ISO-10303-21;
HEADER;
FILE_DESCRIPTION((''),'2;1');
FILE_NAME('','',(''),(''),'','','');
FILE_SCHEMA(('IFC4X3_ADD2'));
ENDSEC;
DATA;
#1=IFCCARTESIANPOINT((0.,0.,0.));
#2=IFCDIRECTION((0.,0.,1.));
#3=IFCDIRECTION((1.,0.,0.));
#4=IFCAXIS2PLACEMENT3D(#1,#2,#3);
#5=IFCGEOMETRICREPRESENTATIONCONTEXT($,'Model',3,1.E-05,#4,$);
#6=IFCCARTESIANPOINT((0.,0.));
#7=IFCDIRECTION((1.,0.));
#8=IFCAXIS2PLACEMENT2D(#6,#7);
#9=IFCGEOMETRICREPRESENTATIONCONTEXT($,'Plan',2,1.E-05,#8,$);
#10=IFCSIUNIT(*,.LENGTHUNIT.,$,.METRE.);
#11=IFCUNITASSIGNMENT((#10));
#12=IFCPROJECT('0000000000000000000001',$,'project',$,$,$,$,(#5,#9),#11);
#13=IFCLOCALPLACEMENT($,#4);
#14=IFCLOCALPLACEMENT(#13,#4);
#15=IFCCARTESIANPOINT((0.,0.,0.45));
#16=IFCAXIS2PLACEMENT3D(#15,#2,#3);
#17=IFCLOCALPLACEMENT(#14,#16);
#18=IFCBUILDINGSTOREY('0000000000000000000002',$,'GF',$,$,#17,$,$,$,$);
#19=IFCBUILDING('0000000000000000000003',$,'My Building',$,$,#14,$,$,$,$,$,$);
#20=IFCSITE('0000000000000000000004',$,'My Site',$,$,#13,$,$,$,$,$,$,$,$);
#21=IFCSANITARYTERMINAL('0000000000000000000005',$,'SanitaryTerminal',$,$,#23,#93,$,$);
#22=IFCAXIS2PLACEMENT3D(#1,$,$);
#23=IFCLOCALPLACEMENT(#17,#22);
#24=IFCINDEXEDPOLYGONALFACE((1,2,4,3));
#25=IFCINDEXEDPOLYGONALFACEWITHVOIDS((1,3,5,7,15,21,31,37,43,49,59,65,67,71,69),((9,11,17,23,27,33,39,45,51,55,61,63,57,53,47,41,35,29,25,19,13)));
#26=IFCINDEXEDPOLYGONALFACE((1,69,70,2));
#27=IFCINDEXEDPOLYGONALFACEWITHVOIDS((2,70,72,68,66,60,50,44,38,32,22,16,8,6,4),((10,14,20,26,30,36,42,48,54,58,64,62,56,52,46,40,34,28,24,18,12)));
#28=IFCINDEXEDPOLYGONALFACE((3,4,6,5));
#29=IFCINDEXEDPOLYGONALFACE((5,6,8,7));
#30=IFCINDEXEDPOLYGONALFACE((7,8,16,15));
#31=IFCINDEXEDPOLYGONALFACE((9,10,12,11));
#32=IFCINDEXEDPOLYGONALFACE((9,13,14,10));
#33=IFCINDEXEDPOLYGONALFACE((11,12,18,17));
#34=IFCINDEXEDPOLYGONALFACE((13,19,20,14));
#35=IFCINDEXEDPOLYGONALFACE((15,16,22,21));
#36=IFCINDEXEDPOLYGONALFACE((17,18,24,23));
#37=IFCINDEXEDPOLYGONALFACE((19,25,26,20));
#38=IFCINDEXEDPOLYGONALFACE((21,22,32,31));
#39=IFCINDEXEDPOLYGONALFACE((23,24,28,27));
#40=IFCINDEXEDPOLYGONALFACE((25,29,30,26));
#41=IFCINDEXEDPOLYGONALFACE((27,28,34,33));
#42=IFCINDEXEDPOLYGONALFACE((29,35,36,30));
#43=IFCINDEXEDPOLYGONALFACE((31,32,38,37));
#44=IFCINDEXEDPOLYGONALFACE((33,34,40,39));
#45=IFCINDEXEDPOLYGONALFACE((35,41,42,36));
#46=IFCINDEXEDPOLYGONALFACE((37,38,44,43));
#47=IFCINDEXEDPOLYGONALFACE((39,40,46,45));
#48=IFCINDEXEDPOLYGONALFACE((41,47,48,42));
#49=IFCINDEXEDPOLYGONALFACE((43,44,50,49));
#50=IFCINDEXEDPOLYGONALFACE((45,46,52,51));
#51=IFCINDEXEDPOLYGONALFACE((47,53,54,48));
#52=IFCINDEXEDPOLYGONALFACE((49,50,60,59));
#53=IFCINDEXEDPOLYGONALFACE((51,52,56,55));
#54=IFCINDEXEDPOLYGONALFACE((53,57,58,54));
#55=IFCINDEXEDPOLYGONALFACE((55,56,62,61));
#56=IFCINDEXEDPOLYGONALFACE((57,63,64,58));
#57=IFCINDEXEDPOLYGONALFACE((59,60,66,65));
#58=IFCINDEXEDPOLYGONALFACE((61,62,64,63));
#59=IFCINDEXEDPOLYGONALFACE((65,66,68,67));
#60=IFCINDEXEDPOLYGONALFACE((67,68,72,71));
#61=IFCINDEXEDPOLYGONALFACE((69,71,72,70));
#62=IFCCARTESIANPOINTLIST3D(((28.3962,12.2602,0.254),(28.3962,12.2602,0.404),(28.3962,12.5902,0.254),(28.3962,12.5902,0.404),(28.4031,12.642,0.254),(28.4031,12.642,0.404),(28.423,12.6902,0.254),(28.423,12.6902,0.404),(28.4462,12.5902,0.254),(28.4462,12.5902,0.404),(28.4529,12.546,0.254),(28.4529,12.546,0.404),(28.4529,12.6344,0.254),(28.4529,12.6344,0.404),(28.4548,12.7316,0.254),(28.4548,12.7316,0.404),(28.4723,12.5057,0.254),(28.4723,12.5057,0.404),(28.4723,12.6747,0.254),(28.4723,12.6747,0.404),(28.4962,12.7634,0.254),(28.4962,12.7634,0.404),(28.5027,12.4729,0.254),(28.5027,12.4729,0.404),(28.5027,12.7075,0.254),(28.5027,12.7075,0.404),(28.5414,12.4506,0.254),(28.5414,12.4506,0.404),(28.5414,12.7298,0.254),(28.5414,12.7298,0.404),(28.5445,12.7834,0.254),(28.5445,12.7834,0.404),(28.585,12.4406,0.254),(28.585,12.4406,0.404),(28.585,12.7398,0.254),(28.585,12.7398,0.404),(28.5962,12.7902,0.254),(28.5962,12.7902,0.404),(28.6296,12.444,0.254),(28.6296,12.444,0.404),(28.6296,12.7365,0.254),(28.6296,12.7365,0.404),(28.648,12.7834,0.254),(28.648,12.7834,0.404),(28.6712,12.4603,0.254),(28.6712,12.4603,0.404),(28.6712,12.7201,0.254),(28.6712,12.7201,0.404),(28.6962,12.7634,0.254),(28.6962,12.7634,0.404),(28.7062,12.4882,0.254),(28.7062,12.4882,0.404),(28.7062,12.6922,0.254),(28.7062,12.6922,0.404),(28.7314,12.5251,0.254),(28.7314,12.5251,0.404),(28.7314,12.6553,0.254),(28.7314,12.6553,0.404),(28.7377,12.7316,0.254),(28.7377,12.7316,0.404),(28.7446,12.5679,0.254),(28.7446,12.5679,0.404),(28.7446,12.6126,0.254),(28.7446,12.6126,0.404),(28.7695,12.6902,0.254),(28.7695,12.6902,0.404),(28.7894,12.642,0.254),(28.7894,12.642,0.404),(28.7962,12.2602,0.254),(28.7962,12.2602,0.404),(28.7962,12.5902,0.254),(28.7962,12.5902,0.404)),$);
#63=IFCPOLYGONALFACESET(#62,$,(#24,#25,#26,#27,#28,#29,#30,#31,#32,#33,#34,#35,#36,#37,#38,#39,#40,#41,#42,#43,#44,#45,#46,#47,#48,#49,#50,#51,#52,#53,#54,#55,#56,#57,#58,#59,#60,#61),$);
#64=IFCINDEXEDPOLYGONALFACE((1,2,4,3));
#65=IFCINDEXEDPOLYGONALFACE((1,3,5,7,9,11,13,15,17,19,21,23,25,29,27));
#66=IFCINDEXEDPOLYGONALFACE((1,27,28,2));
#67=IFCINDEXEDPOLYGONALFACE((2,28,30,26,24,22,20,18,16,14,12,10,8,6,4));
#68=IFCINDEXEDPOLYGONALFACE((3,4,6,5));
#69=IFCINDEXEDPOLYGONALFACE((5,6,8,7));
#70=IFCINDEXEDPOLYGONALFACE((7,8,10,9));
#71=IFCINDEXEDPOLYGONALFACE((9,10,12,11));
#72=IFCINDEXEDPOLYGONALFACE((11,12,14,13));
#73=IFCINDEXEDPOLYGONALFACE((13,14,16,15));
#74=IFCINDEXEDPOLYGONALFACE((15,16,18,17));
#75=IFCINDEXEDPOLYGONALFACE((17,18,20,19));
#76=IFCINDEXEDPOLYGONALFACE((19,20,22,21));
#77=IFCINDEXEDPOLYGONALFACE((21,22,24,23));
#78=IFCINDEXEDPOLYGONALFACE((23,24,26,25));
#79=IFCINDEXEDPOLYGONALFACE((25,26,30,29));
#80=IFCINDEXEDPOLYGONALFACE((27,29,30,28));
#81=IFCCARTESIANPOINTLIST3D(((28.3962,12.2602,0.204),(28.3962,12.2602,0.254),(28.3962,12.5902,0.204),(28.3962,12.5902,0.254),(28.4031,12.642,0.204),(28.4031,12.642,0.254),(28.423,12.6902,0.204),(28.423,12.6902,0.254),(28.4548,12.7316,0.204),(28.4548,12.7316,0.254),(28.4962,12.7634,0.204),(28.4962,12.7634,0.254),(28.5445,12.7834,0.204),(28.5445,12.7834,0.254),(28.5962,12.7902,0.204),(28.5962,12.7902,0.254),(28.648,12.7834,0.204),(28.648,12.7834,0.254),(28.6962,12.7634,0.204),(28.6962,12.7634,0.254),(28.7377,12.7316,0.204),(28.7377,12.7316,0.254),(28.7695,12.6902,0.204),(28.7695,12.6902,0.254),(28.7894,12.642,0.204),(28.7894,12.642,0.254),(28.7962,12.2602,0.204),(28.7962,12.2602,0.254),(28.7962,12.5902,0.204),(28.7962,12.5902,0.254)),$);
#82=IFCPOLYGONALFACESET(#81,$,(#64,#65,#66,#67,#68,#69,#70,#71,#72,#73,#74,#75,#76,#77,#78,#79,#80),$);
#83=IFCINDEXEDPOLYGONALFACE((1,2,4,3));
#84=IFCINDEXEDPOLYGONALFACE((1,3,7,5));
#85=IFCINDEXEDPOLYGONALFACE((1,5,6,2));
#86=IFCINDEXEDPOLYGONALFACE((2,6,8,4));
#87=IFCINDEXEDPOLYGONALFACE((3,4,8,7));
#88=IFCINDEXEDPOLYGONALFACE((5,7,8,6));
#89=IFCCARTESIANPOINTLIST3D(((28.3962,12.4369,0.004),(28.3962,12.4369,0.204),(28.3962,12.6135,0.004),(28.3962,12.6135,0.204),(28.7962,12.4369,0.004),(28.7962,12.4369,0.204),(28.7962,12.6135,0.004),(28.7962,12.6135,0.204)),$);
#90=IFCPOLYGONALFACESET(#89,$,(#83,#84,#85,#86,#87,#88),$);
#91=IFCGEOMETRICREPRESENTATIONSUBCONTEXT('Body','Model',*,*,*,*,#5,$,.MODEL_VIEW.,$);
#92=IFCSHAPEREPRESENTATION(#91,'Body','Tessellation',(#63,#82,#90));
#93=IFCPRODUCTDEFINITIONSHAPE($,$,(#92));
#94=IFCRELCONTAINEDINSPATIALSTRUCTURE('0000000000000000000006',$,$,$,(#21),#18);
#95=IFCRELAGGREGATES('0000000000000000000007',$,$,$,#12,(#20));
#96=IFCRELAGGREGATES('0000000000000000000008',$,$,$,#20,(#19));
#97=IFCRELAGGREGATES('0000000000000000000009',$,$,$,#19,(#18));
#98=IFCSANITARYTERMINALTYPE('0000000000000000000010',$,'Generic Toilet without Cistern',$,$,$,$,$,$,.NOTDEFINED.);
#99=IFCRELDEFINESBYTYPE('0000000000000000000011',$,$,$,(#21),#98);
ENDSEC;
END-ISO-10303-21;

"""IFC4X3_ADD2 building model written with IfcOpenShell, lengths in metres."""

from ifc_helpers import new_model, entity, si_unit, frame, frame_2d, origin_with_axes, origin_2d_with_axis, place, context, subcontext, project, spatial, line, arc, indexed_curve, circle_curve, outline, extrude, shape, source, transform, mapped, type_object, type_shapes, element, save


model = new_model("IFC4X3_ADD2")

# Units and contexts
model_context = context("Model", 3, precision=1e-05, world=origin_with_axes())
plan_context = context("Plan", 2, precision=1e-05, world=origin_2d_with_axis())
body_context_1 = subcontext(model_context, "Body", "Model", "MODEL_VIEW")
body_context_2 = subcontext(plan_context, "Body", "Plan", "PLAN_VIEW")
ifc_project = project(units=[si_unit("LENGTHUNIT", "METRE")], contexts=[model_context, plan_context])

# Site, building, storey
site_placement = place(None, origin_with_axes())
site = spatial("IfcSite", under=ifc_project, at=site_placement, Name="My Site")
building_placement = place(site_placement, origin_with_axes())
building = spatial("IfcBuilding", under=site, at=building_placement, Name="My Building")
storey_placement = place(building_placement, frame((0.0, 0.0, 0.45), z_axis=(0.0, 0.0, 1.0), x_axis=(1.0, 0.0, 0.0)))
storey = spatial("IfcBuildingStorey", under=building, at=storey_placement, Name="GF")

# Sanitary terminal
sanitary_terminal_type_1 = type_object("IfcSanitaryTerminalType", Name="Generic Toilet without Cistern", PredefinedType="NOTDEFINED")
shared_shape_1 = source(origin_with_axes(), body_context_1, "Body", "SweptSolid", [
    extrude(outline(indexed_curve([(-0.2, 0.0), (0.2, 0.0), (0.2, -0.33), (0.1414, -0.4714), (0.0, -0.53), (-0.1414, -0.4714), (-0.2, -0.33)], segments=[line(1, 2), line(2, 3), arc(3, 4, 5), arc(5, 6, 7), line(7, 1)]), holes=[circle_curve(frame_2d((0.0, -0.33)), 0.15)]), frame((0.0, 0.0, 0.25), z_axis=(0.0, 0.0, 1.0), x_axis=(1.0, 0.0, 0.0)), (0.0, 0.0, 1.0), 0.15),
    extrude(outline(indexed_curve([(-0.2, 0.0), (0.2, 0.0), (0.2, -0.33), (0.1414, -0.4714), (0.0, -0.53), (-0.1414, -0.4714), (-0.2, -0.33)], segments=[line(1, 2), line(2, 3), arc(3, 4, 5), arc(5, 6, 7), line(7, 1)])), frame((0.0, 0.0, 0.2), z_axis=(0.0, 0.0, 1.0), x_axis=(1.0, 0.0, 0.0)), (0.0, 0.0, 1.0), 0.05),
    extrude(outline(indexed_curve([(-0.2, -0.1767), (0.2, -0.1767), (0.2, -0.3533), (-0.2, -0.3533)], segments=[line(1, 2, 3, 4, 1)])), origin_with_axes(), (0.0, 0.0, 1.0), 0.2),
])
shared_shape_2 = source(origin_with_axes(), body_context_2, "Body", "GeometricSet", [
    entity("IfcGeometricCurveSet", [entity("IfcIndexedPolyCurve", entity("IfcCartesianPointList2D", [[-0.1068, -0.124], [-0.0957, -0.1129], [-0.0804, -0.1088], [0.0804, -0.1088], [0.0957, -0.1129], [0.1068, -0.124], [0.1109, -0.1393], [0.1109, -0.3476], [0.1025, -0.3926], [0.0784, -0.4308], [0.0424, -0.4563], [0.0, -0.4652], [-0.0424, -0.4563], [-0.0784, -0.4308], [-0.1025, -0.3926], [-0.1109, -0.3476], [-0.1109, -0.1393]]), [entity("IfcLineIndex", [1, 2, 3, 4, 5, 6, 7, 8, 9, 10, 11, 12, 13, 14, 15, 16, 17, 1])]), entity("IfcIndexedPolyCurve", entity("IfcCartesianPointList2D", [[-0.1962, -0.2314], [-0.1848, -0.301], [-0.1764, -0.3339], [-0.1663, -0.3651], [-0.1546, -0.3944], [-0.1414, -0.4213], [-0.1269, -0.4458], [-0.1111, -0.4675], [-0.0943, -0.4862], [-0.0765, -0.5018], [-0.0581, -0.514], [-0.039, -0.5229], [-0.0196, -0.5282], [0.0, -0.53], [0.0196, -0.5282], [0.039, -0.5229], [0.0581, -0.514], [0.0765, -0.5018], [0.0943, -0.4862], [0.1111, -0.4675], [0.1269, -0.4458], [0.1414, -0.4213], [0.1546, -0.3944], [0.1663, -0.3651], [0.1764, -0.3339], [0.1848, -0.301], [0.1962, -0.2314], [0.2, -0.159], [0.1872, 0.0], [-0.1872, 0.0], [-0.2, -0.159]]), [entity("IfcLineIndex", [1, 2, 3, 4, 5, 6, 7, 8, 9, 10, 11, 12, 13, 14, 15, 16, 17, 18, 19, 20, 21, 22, 23, 24, 25, 26, 27, 28, 29, 30, 31, 1])])]),
])
type_shapes(sanitary_terminal_type_1, [shared_shape_1, shared_shape_2])
for number, where, z_axis, x_axis, name in (
    (1, (28.5962, 12.2602, 0.004), (0.0, 0.0, 1.0), (-1.0, 0.0, 0.0), "SanitaryTerminal"),
):
    element("IfcSanitaryTerminal", number, at=place(storey_placement, frame(where, z_axis=z_axis, x_axis=x_axis)), inside=storey, type_object=sanitary_terminal_type_1, Name=name, shapes=[
        shape(body_context_1, "Body", "MappedRepresentation", [mapped(shared_shape_1, transform((0.0, 0.0, 0.0), x_axis=(1.0, 0.0, 0.0), y_axis=(0.0, 1.0, 0.0), z_axis=(0.0, 0.0, 1.0), scale=1.0))]),
        shape(body_context_2, "Body", "MappedRepresentation", [mapped(shared_shape_2, transform((0.0, 0.0, 0.0), x_axis=(1.0, 0.0, 0.0), y_axis=(0.0, 1.0, 0.0), z_axis=(0.0, 0.0, 1.0), scale=1.0))]),
    ])

save(model, "model.ifc")
